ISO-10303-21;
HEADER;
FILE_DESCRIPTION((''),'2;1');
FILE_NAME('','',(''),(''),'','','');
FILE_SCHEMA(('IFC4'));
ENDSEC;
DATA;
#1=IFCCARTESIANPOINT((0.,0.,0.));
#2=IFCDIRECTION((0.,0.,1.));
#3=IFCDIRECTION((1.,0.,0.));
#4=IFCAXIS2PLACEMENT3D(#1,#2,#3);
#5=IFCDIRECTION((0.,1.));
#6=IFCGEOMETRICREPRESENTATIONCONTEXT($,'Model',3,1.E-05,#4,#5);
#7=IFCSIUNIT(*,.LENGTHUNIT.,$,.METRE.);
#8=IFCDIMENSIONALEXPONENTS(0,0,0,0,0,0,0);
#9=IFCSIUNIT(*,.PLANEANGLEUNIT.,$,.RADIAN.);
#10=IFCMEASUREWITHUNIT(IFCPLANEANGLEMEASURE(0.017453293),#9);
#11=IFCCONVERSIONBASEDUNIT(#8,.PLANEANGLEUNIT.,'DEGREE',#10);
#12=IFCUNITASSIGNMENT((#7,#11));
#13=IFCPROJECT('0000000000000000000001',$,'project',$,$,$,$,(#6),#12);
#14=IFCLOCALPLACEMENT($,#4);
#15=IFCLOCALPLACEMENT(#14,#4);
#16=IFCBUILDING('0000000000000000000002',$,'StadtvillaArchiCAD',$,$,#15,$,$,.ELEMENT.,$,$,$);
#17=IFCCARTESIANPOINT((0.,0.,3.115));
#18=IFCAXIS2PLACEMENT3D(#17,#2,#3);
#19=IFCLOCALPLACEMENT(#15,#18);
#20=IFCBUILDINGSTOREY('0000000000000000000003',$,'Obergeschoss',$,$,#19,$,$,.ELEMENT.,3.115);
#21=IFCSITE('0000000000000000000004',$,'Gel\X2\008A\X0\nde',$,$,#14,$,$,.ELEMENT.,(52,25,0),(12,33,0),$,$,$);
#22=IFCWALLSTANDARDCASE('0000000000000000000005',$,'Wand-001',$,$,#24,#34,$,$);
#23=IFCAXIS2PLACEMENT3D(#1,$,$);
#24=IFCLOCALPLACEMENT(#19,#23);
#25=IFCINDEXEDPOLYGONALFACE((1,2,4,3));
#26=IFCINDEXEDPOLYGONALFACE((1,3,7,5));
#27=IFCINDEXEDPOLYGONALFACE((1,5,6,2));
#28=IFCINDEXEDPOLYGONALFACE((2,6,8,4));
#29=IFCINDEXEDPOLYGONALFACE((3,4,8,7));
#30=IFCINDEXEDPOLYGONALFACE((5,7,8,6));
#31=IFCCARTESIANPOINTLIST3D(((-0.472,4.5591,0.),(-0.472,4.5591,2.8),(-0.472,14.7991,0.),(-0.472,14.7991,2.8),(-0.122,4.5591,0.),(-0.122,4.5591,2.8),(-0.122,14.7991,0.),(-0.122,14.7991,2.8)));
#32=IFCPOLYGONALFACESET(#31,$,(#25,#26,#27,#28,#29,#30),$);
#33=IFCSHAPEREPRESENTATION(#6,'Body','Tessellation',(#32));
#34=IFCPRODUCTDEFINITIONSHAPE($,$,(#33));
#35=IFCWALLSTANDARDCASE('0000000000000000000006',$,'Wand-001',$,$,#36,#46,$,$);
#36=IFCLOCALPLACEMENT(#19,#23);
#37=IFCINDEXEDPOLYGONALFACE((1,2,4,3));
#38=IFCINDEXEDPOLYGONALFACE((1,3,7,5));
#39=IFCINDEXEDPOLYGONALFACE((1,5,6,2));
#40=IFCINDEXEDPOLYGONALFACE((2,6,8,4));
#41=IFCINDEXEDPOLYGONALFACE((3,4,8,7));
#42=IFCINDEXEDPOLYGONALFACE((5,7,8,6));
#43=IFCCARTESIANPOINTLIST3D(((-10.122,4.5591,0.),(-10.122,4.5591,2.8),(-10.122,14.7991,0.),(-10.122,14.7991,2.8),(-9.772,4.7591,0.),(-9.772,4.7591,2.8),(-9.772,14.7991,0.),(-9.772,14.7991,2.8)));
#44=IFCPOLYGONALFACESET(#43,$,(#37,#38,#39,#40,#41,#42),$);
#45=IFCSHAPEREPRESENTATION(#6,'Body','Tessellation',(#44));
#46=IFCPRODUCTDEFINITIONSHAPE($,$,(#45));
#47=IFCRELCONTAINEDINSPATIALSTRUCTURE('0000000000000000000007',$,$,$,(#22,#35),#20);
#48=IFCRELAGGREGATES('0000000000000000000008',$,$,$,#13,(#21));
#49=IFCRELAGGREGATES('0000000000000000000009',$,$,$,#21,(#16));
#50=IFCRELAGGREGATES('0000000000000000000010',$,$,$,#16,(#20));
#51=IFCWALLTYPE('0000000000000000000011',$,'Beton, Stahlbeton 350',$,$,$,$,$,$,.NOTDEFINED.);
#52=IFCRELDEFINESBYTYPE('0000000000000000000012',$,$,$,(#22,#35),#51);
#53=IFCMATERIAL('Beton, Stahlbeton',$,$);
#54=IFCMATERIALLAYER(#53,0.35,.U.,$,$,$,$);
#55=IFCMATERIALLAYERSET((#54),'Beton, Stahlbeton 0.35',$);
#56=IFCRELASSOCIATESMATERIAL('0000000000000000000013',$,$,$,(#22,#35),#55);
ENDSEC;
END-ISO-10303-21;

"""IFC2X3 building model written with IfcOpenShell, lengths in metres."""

from ifc_helpers import new_model, entity, si_unit, converted_unit, direction, frame, origin_with_axes, place, context, project, spatial, polyline, outline, extrude, material, layer, layer_set, layer_usage, type_object, element, save


model = new_model("IFC2X3")

# Units and contexts
model_context = context("Model", 3, precision=1e-05, world=origin_with_axes(), true_north=direction((0.0, 1.0)))
ifc_project = project(units=[si_unit("LENGTHUNIT", "METRE"), converted_unit("PLANEANGLEUNIT", "DEGREE", entity("IfcPlaneAngleMeasure", 0.017453293), si_unit("PLANEANGLEUNIT", "RADIAN"), dimensions=[0, 0, 0, 0, 0, 0, 0])], contexts=[model_context])

# Site, building, storey
site_placement = place(None, origin_with_axes())
site = spatial("IfcSite", under=ifc_project, at=site_placement, Name="Gel\u008ande", CompositionType="ELEMENT", RefLatitude=(52, 25, 0), RefLongitude=(12, 33, 0))
building_placement = place(site_placement, origin_with_axes())
building = spatial("IfcBuilding", under=site, at=building_placement, Name="StadtvillaArchiCAD", CompositionType="ELEMENT")
storey_placement = place(building_placement, frame((0.0, 0.0, 3.115), z_axis=(0.0, 0.0, 1.0), x_axis=(1.0, 0.0, 0.0)))
storey = spatial("IfcBuildingStorey", under=building, at=storey_placement, Name="Obergeschoss", CompositionType="ELEMENT", Elevation=3.115)

# Shared definitions
ifc_material_1 = material(Name="Beton, Stahlbeton")

# Walls
ifc_layer_1 = layer(ifc_material_1, 0.35, ventilated="UNKNOWN")
ifc_layer_set_1 = layer_set([ifc_layer_1], Name="Beton, Stahlbeton 0.35")
ifc_layer_usage_1 = layer_usage(ifc_layer_set_1, "AXIS2", "NEGATIVE", 0.0)
wall_type_1 = type_object("IfcWallType", Name="Beton, Stahlbeton 350", PredefinedType="NOTDEFINED")
wall_1_placement = place(storey_placement, frame((-0.122, 14.7991, 0.0), z_axis=(0.0, 0.0, 1.0), x_axis=(0.0, -1.0, 0.0)))
element("IfcWallStandardCase", 1, at=wall_1_placement, inside=storey, type_object=wall_type_1, material=ifc_layer_usage_1, Name="Wand-001", context=model_context, shape_type="SweptSolid", body=[
    extrude(outline(polyline([(0.0, -0.35), (10.24, -0.35), (10.24, 0.0), (0.0, 0.0), (0.0, -0.35)])), origin_with_axes(), (0.0, 0.0, 1.0), 2.8),
])
ifc_layer_usage_2 = layer_usage(ifc_layer_set_1, "AXIS2", "NEGATIVE", 0.0)
wall_2_placement = place(storey_placement, frame((-9.772, 14.7991, 0.0), z_axis=(0.0, 0.0, 1.0), x_axis=(0.0, -1.0, 0.0)))
element("IfcWallStandardCase", 2, at=wall_2_placement, inside=storey, type_object=wall_type_1, material=ifc_layer_usage_2, Name="Wand-001", context=model_context, shape_type="SweptSolid", body=[
    extrude(outline(polyline([(0.0, -0.35), (10.24, -0.35), (10.04, 0.0), (0.0, 0.0), (0.0, -0.35)])), origin_with_axes(), (0.0, 0.0, 1.0), 2.8),
])

save(model, "model.ifc")
